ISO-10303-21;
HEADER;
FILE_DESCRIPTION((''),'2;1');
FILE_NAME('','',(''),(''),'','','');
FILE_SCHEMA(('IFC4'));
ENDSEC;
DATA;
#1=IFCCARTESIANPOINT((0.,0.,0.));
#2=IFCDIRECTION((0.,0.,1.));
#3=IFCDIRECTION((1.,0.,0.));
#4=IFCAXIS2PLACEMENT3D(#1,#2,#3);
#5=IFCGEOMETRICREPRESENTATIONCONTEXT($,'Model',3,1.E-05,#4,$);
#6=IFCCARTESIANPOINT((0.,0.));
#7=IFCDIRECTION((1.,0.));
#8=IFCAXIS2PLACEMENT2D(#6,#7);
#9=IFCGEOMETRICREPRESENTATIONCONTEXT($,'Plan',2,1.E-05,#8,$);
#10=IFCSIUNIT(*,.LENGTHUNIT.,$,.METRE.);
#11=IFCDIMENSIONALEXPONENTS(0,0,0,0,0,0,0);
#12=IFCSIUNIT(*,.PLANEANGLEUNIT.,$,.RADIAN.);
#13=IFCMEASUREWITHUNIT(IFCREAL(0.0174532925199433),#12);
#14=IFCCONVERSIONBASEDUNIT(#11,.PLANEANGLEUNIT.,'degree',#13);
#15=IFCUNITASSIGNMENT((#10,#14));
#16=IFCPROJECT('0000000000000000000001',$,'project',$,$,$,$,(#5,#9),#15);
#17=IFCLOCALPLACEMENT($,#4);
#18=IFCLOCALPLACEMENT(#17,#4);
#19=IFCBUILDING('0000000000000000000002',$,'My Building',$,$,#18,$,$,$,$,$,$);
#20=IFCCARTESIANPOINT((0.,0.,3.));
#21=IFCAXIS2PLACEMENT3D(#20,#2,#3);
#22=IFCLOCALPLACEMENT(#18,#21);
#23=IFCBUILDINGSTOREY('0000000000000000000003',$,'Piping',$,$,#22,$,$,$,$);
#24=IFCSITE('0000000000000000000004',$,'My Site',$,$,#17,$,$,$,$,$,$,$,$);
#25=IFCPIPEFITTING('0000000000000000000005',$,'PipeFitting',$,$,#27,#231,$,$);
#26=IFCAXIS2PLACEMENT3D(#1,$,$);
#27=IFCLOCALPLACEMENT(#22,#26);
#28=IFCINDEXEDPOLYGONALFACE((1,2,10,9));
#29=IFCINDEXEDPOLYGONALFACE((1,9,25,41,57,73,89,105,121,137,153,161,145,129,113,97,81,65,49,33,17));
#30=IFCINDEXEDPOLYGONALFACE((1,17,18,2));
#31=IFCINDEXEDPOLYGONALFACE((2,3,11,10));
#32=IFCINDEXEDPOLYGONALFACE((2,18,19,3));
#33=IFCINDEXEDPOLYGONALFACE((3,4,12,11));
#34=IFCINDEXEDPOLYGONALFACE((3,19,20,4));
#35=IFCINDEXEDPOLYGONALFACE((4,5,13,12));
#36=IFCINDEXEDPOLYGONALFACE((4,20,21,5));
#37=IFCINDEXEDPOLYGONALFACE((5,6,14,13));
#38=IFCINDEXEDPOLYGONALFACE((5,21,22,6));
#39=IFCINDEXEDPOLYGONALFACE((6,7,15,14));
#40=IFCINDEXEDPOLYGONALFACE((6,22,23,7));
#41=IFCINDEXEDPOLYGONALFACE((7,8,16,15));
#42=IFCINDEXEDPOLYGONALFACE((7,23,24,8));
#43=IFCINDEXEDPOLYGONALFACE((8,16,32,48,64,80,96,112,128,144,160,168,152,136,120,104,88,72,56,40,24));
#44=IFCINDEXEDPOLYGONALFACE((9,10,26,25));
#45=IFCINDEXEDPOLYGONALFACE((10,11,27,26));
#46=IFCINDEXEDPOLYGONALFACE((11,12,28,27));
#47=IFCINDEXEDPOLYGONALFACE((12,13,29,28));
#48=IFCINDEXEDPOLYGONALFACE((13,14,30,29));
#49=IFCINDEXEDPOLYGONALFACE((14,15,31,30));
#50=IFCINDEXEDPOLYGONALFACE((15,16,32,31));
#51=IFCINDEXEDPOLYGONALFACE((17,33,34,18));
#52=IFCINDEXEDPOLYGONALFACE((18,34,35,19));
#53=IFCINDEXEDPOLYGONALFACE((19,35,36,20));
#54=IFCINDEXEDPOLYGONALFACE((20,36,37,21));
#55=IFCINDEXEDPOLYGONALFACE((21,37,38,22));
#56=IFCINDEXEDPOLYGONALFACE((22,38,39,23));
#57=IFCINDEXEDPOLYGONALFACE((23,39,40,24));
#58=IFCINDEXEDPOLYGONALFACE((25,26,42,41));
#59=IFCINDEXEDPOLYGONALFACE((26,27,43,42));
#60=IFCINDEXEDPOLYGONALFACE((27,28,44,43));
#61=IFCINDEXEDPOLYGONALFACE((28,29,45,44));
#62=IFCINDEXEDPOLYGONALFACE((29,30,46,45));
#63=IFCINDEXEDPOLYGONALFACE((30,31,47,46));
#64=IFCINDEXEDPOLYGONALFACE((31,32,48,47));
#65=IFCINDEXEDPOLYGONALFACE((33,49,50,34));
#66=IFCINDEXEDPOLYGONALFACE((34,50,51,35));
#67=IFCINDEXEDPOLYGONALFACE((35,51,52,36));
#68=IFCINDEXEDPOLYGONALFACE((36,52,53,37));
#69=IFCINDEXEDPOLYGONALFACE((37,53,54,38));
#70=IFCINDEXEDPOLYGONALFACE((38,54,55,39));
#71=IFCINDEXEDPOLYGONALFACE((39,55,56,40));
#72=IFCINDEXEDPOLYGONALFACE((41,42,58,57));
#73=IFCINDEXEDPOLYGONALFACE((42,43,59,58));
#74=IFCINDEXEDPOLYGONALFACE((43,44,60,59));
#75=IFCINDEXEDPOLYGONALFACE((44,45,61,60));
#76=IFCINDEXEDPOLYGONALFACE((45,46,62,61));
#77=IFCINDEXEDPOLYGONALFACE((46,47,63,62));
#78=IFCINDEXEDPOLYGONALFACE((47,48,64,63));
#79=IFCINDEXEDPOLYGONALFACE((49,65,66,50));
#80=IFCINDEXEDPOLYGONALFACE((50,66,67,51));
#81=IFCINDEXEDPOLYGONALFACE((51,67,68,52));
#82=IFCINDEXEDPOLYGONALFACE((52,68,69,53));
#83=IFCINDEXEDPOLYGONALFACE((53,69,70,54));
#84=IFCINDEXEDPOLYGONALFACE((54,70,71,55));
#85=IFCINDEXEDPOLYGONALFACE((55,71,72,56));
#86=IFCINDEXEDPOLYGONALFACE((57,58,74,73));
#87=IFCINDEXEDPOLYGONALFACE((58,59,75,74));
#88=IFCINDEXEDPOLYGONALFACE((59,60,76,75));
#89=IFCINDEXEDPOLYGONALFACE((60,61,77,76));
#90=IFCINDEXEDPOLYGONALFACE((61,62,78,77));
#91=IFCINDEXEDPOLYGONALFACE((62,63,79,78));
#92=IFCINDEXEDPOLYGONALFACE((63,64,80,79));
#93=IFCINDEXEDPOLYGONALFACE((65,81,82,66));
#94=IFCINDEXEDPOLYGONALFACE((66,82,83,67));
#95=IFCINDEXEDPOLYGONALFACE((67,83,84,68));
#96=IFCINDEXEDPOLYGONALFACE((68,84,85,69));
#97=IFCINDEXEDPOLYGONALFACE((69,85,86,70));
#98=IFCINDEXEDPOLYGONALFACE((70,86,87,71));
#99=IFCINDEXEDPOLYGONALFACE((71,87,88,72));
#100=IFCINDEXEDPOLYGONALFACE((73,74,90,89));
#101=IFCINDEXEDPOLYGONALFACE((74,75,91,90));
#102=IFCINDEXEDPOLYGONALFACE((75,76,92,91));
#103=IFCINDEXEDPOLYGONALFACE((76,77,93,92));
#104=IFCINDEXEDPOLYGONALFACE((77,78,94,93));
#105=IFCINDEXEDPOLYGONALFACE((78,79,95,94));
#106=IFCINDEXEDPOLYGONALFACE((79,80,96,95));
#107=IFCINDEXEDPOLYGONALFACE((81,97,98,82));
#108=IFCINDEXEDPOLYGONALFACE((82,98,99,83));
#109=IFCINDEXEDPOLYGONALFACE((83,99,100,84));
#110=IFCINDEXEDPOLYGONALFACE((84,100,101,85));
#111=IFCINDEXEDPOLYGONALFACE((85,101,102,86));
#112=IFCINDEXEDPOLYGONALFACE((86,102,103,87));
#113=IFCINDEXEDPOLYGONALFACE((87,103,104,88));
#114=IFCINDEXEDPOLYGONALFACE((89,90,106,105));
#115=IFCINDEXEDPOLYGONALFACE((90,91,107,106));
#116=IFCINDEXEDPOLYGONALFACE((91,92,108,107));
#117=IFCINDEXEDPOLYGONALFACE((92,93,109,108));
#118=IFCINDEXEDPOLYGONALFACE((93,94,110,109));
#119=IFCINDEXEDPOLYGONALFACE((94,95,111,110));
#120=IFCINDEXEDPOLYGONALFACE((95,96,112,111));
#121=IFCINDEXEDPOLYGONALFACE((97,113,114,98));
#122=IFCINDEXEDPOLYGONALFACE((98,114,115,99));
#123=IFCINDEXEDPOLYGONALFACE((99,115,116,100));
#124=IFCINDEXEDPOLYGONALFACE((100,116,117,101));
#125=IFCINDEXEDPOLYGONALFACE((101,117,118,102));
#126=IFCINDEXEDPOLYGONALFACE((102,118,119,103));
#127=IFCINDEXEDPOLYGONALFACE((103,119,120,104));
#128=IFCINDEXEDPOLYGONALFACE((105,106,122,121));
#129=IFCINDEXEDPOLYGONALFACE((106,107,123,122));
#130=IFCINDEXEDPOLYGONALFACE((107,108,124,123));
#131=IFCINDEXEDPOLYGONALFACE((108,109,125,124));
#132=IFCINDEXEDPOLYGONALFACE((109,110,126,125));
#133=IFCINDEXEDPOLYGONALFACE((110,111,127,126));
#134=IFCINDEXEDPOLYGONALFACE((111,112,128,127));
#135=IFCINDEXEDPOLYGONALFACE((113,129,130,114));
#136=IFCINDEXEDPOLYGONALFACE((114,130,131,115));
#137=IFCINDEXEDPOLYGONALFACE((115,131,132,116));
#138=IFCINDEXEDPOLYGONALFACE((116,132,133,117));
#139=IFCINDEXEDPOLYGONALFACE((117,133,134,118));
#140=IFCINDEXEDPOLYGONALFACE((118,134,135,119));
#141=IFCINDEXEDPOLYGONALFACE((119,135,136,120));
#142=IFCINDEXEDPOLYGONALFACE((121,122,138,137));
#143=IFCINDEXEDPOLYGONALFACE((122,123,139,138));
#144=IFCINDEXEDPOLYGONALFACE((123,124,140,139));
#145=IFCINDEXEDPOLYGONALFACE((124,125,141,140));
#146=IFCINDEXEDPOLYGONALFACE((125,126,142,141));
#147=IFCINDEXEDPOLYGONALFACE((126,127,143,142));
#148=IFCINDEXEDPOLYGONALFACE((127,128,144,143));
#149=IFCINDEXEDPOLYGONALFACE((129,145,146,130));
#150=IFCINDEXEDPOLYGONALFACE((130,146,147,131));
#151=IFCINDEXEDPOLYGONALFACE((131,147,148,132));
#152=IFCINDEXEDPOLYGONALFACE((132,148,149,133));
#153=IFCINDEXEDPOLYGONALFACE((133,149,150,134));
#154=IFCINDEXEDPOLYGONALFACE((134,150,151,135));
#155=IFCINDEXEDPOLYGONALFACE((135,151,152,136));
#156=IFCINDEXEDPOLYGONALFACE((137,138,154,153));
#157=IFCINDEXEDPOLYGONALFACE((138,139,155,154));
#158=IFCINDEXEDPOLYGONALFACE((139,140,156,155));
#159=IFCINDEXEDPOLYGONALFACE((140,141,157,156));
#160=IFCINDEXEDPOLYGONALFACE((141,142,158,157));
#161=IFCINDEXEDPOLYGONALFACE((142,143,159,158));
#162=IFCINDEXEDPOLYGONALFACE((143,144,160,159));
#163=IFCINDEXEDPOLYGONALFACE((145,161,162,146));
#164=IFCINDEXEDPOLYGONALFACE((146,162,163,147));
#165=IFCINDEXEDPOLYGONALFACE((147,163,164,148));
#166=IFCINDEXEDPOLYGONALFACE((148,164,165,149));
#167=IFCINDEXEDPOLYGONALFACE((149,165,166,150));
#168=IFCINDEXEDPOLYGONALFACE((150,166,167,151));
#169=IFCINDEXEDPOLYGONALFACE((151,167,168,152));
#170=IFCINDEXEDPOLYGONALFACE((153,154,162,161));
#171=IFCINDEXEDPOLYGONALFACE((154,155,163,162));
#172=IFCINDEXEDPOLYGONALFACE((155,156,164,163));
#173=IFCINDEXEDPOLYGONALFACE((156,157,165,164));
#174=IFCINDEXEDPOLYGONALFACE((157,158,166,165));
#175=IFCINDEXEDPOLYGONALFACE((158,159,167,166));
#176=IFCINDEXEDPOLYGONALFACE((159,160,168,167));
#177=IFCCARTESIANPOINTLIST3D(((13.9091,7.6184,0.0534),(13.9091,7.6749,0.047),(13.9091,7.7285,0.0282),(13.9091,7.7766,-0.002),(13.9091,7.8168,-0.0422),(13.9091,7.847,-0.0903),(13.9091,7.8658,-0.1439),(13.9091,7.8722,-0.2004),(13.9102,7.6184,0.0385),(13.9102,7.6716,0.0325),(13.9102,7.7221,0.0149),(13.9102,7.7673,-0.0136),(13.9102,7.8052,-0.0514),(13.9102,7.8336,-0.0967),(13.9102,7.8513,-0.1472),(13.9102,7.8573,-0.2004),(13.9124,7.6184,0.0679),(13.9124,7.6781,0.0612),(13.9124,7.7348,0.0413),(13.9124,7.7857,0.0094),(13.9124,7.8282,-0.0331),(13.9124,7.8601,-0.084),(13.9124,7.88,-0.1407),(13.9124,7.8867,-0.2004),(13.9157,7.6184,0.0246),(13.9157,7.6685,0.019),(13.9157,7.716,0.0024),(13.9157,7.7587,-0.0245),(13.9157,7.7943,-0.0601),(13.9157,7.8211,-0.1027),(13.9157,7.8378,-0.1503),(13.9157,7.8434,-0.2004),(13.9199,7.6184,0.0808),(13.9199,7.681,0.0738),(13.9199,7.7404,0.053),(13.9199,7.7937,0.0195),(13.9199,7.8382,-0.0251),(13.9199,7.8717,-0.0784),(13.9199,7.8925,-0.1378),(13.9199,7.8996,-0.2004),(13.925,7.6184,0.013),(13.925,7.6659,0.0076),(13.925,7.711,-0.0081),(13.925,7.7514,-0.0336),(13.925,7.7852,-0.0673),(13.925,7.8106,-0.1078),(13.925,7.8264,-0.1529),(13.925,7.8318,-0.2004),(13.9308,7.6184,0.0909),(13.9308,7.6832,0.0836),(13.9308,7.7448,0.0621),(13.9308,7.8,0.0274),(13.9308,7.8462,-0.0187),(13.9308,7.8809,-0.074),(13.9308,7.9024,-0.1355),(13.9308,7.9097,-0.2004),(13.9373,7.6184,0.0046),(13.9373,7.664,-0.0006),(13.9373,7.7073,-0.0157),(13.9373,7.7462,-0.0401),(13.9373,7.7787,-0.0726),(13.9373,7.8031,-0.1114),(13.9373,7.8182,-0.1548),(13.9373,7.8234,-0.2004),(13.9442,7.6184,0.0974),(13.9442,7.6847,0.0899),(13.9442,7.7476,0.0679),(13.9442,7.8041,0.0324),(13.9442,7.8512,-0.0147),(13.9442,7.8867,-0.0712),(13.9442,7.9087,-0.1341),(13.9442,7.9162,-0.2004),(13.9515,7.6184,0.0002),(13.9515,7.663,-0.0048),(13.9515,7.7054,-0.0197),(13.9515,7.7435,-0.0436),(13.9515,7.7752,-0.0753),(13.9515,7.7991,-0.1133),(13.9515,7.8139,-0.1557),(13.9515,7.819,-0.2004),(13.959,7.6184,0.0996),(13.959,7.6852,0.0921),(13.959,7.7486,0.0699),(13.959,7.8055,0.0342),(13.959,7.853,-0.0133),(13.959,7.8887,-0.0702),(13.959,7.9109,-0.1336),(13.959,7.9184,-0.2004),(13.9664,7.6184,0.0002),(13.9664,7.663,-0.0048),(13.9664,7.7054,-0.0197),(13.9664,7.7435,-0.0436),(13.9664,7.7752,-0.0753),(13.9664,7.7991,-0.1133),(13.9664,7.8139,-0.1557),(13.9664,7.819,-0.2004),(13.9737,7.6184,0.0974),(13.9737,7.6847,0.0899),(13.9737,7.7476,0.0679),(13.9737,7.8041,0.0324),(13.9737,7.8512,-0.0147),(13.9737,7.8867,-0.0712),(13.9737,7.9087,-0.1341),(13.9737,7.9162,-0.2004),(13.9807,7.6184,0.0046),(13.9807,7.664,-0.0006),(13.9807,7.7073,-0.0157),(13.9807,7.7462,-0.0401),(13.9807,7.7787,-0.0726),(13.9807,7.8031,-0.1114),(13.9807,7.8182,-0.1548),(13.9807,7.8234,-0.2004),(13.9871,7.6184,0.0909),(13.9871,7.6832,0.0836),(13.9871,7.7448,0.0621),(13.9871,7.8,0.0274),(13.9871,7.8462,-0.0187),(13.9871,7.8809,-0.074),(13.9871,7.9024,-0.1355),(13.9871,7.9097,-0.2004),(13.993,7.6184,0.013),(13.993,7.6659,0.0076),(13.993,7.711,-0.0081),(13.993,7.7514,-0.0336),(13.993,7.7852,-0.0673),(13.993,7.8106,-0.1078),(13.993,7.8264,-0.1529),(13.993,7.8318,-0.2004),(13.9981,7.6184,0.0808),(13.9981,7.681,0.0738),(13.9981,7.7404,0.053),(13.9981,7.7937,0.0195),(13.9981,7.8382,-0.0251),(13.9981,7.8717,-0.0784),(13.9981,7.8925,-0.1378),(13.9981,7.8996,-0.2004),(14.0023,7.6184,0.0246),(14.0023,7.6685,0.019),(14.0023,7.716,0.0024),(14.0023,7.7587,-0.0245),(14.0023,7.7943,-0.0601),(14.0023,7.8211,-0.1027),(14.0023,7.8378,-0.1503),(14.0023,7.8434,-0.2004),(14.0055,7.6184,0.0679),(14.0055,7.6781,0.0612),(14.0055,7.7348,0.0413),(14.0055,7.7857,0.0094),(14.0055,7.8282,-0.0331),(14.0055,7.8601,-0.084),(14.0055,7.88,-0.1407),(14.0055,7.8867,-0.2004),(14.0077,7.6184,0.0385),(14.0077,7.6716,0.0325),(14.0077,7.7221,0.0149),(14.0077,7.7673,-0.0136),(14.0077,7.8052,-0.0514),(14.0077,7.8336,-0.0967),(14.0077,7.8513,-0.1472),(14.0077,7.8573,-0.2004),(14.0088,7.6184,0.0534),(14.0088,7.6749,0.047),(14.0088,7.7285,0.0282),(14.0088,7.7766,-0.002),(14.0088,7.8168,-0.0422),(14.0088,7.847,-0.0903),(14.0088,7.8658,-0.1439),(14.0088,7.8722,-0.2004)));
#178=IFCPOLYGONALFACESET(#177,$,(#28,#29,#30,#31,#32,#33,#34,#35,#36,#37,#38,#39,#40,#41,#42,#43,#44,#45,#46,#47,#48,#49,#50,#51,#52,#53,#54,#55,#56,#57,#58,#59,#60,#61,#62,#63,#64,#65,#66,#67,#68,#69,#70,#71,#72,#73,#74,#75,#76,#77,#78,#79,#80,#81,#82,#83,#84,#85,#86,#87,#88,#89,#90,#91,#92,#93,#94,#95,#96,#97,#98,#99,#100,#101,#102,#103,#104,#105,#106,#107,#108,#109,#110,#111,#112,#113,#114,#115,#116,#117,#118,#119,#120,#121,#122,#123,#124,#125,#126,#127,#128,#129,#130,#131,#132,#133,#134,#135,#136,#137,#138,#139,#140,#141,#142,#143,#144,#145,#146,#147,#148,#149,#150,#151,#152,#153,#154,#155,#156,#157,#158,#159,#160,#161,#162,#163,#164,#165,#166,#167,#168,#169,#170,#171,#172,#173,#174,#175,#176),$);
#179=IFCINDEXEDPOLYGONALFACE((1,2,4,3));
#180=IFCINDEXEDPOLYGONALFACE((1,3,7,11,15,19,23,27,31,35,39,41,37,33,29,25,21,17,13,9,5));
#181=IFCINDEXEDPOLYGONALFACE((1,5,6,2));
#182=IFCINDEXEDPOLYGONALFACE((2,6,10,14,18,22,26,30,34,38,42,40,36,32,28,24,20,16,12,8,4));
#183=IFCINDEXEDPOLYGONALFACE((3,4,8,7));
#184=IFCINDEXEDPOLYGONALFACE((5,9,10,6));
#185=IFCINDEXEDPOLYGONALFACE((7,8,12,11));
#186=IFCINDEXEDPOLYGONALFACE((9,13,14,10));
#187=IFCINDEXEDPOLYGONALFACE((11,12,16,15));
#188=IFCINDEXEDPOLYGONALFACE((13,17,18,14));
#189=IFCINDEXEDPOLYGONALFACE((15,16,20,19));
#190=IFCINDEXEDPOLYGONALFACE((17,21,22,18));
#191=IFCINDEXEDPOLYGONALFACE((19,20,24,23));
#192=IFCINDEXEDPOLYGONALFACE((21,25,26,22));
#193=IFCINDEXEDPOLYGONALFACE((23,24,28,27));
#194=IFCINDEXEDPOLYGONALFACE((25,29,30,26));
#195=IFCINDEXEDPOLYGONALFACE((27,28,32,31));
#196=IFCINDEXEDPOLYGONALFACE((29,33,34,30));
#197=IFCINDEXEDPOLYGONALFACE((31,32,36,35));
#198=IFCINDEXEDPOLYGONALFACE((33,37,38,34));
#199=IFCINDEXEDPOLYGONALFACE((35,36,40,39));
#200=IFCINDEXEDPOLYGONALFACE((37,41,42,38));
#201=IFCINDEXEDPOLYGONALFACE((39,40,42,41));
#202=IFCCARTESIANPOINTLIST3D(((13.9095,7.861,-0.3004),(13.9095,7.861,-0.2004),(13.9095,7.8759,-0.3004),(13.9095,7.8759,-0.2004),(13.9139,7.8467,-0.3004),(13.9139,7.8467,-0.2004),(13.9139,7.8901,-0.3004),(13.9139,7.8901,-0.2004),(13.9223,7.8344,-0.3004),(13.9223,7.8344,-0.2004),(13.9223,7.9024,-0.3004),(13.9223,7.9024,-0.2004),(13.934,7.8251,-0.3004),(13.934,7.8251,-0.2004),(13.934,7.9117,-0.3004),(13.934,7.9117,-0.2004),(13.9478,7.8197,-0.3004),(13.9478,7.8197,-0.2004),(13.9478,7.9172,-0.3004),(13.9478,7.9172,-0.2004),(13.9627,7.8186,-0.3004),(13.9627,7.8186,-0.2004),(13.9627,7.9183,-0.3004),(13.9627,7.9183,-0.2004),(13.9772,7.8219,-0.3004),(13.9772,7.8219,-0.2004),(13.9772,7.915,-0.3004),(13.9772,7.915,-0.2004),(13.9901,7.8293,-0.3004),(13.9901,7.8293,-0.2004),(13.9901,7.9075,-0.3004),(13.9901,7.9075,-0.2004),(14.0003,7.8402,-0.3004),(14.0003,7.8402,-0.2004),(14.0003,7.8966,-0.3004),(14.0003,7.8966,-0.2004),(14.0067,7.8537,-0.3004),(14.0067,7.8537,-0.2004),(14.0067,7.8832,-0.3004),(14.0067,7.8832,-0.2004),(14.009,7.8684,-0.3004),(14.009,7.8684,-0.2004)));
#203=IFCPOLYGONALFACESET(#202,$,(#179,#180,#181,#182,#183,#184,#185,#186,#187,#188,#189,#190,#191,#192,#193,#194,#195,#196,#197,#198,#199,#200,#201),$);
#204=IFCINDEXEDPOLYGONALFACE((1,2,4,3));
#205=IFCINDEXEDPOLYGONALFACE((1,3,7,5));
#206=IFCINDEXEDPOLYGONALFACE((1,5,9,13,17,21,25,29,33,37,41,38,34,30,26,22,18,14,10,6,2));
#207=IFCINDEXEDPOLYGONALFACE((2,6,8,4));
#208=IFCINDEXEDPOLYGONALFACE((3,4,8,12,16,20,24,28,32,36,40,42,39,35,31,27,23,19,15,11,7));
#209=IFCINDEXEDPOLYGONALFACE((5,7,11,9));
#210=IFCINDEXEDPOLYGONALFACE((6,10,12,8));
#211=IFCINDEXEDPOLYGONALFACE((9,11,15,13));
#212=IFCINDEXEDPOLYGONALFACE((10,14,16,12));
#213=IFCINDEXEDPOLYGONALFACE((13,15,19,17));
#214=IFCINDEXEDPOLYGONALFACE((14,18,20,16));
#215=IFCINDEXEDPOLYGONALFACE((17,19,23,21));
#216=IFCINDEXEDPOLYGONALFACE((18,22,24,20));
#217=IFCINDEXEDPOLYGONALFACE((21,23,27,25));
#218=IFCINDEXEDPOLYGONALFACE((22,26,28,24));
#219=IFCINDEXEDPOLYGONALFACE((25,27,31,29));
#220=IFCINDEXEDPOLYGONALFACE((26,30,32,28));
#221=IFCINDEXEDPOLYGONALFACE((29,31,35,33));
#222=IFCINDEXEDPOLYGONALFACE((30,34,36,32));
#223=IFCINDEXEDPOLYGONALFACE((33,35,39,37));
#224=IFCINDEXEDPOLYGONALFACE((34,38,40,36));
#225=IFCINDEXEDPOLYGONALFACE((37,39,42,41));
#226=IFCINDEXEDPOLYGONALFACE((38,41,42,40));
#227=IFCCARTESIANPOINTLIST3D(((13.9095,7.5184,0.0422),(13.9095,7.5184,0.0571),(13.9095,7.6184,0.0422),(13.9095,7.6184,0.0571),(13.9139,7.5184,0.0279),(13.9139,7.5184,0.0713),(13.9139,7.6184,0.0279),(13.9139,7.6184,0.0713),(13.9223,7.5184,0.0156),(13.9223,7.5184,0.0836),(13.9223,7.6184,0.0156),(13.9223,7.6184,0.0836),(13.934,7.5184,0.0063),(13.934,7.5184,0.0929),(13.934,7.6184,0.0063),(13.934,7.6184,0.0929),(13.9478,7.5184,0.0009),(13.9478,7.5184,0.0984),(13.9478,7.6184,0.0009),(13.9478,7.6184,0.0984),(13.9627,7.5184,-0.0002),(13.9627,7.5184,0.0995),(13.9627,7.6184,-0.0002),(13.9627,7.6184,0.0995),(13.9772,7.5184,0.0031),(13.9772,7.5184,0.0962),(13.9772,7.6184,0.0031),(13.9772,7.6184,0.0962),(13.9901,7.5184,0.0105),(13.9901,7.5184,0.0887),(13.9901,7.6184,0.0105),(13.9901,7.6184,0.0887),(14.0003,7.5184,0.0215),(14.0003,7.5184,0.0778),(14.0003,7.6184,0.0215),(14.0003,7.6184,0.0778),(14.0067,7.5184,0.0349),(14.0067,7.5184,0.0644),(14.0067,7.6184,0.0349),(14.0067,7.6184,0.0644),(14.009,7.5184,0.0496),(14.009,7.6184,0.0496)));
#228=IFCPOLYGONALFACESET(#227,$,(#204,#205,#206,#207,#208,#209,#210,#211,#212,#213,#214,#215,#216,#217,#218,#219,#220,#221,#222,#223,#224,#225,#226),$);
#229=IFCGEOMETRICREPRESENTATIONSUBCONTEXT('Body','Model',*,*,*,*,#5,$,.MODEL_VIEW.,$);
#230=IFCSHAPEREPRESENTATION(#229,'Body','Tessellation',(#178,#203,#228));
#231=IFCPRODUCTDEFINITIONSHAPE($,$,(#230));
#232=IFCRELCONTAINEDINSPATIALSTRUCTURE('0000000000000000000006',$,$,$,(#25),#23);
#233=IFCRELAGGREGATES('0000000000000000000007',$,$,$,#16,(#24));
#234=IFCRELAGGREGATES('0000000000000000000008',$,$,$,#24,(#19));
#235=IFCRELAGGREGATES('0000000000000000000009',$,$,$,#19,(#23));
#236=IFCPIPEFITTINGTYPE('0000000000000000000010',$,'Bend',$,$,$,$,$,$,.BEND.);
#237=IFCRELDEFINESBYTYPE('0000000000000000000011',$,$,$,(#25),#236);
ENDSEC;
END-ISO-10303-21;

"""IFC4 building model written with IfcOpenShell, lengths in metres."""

from ifc_helpers import new_model, entity, si_unit, converted_unit, frame, origin_with_axes, origin_2d_with_axis, place, context, subcontext, project, spatial, circle, extrude, source, transform, mapped, type_object, type_shapes, element, save


model = new_model("IFC4")

# Units and contexts
model_context = context("Model", 3, precision=1e-05, world=origin_with_axes())
plan_context = context("Plan", 2, precision=1e-05, world=origin_2d_with_axis())
body_context = subcontext(model_context, "Body", "Model", "MODEL_VIEW")
ifc_project = project(units=[si_unit("LENGTHUNIT", "METRE"), converted_unit("PLANEANGLEUNIT", "degree", entity("IfcReal", 0.0174532925199433), si_unit("PLANEANGLEUNIT", "RADIAN"), dimensions=[0, 0, 0, 0, 0, 0, 0])], contexts=[model_context, plan_context])

# Site, building, storey
site_placement = place(None, origin_with_axes())
site = spatial("IfcSite", under=ifc_project, at=site_placement, Name="My Site")
building_placement = place(site_placement, origin_with_axes())
building = spatial("IfcBuilding", under=site, at=building_placement, Name="My Building")
storey_placement = place(building_placement, frame((0.0, 0.0, 3.0), z_axis=(0.0, 0.0, 1.0), x_axis=(1.0, 0.0, 0.0)))
storey = spatial("IfcBuildingStorey", under=building, at=storey_placement, Name="Piping")

# Pipe fitting
pipe_fitting_type = type_object("IfcPipeFittingType", Name="Bend", PredefinedType="BEND")
shared_shape = source(origin_with_axes(), body_context, "Body", "SolidModel", [
    entity("IfcSweptDiskSolid", entity("IfcIndexedPolyCurve", entity("IfcCartesianPointList3D", [[0.0, 0.0, -0.1], [0.0, 0.0732, -0.2768], [0.0, 0.25, -0.35]]), [entity("IfcArcIndex", [1, 2, 3])]), 0.05),
    extrude(circle(Radius=0.05), origin_with_axes(), (0.0, 0.0, -1.0), 0.1),
    extrude(circle(Radius=0.05), frame((0.0, 0.25, -0.35), z_axis=(0.0, 1.0, 0.000007), x_axis=(1.0, 0.0, 0.0)), (0.0, 0.0, 1.0), 0.1),
])
type_shapes(pipe_fitting_type, [shared_shape])
for number, where, z_axis, x_axis, name in (
    (1, (13.959, 7.8684, -0.3004), (0.0, 0.0, -1.0), (1.0, 0.0, 0.0), "PipeFitting"),
):
    element("IfcPipeFitting", number, at=place(storey_placement, frame(where, z_axis=z_axis, x_axis=x_axis)), inside=storey, type_object=pipe_fitting_type, Name=name, context=body_context, shape_type="MappedRepresentation", body=[
        mapped(shared_shape, transform((0.0, 0.0, 0.0), x_axis=(1.0, 0.0, 0.0), y_axis=(0.0, 1.0, 0.0), z_axis=(0.0, 0.0, 1.0), scale=1.0)),
    ])

save(model, "model.ifc")
